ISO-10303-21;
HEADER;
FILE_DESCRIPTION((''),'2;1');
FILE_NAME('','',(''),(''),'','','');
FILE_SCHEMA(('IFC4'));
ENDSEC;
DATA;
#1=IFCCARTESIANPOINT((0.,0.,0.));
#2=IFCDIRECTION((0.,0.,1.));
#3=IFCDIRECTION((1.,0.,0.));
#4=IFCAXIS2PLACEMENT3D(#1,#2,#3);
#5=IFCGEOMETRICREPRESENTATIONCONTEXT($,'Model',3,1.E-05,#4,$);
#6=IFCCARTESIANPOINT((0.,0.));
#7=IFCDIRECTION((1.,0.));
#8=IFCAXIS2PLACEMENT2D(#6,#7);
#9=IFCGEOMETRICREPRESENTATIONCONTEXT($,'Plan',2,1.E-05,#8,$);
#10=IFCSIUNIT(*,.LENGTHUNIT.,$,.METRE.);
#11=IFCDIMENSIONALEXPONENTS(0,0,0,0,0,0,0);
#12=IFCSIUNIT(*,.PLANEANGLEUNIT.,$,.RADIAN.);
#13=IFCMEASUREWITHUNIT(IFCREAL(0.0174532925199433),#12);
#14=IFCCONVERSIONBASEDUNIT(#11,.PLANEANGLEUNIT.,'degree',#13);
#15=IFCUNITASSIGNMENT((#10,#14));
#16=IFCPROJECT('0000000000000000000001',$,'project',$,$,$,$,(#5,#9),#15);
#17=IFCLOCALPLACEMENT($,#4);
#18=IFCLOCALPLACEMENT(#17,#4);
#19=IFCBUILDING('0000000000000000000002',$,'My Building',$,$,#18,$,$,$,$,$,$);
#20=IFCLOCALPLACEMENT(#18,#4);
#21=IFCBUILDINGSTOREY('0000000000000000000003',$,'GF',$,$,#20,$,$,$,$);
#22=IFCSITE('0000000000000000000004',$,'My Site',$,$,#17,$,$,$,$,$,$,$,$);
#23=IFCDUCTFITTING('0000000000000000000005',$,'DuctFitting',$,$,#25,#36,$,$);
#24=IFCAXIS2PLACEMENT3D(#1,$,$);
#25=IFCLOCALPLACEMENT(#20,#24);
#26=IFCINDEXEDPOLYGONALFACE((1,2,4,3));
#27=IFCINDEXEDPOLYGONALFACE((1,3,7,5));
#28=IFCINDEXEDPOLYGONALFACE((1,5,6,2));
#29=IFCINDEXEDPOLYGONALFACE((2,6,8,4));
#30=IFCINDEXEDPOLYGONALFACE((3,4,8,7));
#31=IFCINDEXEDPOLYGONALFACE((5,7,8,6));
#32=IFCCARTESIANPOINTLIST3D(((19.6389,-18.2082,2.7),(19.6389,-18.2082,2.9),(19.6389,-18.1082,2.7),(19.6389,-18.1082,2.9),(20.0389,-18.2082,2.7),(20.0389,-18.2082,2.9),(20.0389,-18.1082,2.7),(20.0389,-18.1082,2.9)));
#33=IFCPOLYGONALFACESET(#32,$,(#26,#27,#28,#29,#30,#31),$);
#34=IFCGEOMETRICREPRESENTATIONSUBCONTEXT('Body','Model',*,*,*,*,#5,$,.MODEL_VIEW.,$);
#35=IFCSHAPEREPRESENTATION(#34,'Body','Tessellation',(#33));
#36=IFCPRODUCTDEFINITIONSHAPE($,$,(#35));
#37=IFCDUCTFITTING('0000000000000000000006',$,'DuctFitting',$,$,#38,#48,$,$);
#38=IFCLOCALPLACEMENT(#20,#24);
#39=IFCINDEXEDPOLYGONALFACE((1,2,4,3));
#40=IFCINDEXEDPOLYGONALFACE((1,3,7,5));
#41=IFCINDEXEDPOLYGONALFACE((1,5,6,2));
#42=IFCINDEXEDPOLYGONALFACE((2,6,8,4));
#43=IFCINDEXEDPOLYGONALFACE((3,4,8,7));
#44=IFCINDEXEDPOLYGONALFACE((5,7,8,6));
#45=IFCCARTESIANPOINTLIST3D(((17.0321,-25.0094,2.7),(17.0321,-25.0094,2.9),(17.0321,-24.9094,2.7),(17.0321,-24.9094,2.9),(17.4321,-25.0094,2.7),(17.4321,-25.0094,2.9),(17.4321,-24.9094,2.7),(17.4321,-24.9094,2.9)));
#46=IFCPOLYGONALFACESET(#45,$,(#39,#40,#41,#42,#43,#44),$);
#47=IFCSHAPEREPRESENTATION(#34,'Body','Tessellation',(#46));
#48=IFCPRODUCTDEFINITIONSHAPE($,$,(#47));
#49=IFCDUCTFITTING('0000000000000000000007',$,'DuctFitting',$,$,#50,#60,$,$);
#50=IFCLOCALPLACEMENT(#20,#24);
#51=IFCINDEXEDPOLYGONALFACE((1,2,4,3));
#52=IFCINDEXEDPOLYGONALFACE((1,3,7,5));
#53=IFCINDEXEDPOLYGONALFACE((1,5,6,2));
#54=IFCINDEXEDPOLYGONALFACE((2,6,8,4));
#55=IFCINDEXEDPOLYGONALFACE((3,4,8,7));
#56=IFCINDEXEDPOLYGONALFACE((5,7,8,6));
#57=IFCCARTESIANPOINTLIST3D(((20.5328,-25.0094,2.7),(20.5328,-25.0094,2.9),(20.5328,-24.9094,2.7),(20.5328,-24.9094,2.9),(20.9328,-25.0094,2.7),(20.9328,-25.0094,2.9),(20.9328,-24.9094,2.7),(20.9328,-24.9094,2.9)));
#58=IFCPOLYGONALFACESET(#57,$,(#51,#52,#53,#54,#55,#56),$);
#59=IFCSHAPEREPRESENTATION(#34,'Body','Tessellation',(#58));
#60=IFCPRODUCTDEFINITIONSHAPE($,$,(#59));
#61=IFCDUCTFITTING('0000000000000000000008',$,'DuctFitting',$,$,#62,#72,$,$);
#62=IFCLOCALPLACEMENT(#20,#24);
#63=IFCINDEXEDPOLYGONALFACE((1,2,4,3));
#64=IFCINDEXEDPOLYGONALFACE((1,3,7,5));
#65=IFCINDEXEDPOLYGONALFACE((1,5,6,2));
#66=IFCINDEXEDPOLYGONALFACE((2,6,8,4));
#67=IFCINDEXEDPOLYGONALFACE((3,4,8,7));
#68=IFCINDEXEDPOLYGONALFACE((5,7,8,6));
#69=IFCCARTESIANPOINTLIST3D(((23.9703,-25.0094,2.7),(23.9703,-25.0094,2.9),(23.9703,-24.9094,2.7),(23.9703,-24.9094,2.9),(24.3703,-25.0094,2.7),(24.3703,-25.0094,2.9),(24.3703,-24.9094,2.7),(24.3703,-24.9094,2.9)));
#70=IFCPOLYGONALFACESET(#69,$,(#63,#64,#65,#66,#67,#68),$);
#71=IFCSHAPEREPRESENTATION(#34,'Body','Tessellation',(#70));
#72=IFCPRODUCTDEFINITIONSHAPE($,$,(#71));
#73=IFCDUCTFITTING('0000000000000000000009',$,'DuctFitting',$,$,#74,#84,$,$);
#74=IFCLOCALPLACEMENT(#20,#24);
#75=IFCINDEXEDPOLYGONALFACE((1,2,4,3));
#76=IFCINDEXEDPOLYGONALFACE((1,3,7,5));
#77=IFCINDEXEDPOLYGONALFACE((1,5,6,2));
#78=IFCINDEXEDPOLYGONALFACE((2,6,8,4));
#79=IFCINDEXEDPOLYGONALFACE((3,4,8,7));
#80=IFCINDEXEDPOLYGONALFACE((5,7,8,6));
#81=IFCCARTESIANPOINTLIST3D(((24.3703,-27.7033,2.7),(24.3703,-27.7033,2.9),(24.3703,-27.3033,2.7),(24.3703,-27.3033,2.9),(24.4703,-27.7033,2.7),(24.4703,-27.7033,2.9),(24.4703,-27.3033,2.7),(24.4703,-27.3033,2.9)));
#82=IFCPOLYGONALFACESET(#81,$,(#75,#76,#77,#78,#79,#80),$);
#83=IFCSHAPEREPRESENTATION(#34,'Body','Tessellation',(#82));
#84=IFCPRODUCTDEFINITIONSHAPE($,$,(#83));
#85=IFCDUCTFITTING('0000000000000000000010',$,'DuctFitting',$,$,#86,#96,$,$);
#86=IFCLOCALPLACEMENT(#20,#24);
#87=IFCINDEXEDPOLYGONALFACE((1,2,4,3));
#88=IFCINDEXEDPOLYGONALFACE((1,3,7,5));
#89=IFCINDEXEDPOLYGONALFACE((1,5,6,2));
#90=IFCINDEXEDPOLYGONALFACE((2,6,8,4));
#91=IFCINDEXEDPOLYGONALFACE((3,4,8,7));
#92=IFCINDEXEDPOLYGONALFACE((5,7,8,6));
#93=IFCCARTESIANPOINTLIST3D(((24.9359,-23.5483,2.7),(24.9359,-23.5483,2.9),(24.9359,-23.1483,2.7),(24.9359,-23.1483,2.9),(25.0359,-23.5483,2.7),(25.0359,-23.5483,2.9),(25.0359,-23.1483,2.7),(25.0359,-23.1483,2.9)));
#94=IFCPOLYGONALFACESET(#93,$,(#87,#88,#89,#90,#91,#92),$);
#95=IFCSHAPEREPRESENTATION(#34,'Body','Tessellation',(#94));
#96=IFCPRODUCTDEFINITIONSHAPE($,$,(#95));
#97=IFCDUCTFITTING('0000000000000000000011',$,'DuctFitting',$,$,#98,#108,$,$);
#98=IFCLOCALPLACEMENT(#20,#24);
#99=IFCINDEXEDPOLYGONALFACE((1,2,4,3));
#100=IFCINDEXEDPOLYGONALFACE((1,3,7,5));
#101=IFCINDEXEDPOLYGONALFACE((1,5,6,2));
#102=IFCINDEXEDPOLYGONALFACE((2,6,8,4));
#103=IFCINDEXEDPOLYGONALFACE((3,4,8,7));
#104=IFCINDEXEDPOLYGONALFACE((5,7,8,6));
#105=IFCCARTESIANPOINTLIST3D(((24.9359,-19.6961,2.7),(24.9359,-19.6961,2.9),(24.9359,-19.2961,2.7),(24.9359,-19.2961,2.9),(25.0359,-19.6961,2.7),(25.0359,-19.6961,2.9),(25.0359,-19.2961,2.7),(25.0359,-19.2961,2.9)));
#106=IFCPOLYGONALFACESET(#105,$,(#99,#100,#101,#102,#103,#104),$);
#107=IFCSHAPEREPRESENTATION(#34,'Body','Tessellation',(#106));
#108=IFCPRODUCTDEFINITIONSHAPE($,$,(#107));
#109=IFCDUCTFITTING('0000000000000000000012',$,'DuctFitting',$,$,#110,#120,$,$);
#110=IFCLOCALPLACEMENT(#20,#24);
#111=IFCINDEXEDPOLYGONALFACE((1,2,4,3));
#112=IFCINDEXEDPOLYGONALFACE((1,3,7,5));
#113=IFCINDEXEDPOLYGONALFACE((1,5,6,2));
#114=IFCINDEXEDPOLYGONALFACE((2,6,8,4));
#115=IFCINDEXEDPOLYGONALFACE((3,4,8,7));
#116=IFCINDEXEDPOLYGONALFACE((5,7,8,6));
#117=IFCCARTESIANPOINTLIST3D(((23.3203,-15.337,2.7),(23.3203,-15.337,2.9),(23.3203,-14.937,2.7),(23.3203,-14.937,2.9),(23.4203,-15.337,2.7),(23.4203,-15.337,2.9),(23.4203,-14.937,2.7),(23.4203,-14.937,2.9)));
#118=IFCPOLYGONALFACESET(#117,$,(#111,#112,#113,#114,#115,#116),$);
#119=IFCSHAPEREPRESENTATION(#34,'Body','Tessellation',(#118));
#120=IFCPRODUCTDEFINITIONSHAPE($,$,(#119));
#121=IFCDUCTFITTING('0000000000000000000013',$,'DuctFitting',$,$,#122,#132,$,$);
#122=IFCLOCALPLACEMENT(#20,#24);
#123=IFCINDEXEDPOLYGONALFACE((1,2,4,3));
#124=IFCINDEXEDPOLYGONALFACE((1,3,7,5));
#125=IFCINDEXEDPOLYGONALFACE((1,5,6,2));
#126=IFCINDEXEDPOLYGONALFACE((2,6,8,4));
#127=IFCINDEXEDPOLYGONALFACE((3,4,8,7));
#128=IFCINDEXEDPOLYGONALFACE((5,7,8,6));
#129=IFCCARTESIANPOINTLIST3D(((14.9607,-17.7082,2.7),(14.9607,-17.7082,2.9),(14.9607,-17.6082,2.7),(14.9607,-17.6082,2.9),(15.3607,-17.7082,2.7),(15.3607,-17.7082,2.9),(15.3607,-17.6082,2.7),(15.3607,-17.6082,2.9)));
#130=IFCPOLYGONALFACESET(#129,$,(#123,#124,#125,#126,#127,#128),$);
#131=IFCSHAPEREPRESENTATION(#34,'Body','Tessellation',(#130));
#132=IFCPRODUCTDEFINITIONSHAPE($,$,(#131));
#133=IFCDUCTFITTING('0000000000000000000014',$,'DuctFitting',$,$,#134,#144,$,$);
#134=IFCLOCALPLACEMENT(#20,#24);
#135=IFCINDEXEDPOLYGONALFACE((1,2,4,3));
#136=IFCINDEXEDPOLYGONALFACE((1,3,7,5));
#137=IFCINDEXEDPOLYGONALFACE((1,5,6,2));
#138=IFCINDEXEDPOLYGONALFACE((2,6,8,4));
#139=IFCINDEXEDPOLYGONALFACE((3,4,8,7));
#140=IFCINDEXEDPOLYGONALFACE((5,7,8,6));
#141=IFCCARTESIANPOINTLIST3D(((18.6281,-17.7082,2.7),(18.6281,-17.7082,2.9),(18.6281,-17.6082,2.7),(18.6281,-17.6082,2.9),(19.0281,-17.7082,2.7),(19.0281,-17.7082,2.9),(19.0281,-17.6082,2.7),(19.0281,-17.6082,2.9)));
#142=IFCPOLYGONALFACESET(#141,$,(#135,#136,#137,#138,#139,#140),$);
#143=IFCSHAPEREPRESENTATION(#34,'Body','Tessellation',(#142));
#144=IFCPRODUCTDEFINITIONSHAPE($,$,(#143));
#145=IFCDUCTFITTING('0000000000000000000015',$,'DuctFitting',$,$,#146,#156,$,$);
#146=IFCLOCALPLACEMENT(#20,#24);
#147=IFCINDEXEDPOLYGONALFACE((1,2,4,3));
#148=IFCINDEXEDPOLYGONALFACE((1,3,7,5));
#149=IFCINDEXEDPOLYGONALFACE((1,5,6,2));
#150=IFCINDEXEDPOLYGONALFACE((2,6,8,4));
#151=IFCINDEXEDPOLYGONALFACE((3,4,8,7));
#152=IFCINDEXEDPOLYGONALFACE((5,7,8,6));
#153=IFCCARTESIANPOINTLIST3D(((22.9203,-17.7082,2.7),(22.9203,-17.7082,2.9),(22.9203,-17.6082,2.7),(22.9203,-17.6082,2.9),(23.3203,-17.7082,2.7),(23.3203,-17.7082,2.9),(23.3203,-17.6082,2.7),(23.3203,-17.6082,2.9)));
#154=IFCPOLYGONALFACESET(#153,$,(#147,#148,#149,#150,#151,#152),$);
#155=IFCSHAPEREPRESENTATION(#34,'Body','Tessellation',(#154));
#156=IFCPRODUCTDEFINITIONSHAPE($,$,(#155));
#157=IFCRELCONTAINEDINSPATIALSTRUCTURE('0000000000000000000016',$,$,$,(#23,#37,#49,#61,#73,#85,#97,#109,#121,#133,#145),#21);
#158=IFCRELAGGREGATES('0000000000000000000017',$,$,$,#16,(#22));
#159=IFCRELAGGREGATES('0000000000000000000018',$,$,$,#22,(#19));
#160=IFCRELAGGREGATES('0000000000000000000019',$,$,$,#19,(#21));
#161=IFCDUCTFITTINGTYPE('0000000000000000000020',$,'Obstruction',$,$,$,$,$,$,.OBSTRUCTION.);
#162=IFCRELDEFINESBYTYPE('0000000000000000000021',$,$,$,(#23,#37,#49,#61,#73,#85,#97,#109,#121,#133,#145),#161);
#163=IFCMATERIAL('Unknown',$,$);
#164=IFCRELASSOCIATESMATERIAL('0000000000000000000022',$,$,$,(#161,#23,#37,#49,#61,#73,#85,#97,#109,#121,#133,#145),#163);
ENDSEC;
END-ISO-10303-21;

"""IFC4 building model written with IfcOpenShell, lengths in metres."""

from ifc_helpers import new_model, entity, si_unit, converted_unit, frame, origin_with_axes, origin_2d_with_axis, place, context, subcontext, project, spatial, rectangle, extrude, material, material_profile, profile_set, profile_usage, type_object, element, save


model = new_model("IFC4")

# Units and contexts
model_context = context("Model", 3, precision=1e-05, world=origin_with_axes())
plan_context = context("Plan", 2, precision=1e-05, world=origin_2d_with_axis())
body_context_1 = subcontext(model_context, "Body", "Model", "MODEL_VIEW")
ifc_project = project(units=[si_unit("LENGTHUNIT", "METRE"), converted_unit("PLANEANGLEUNIT", "degree", entity("IfcReal", 0.0174532925199433), si_unit("PLANEANGLEUNIT", "RADIAN"), dimensions=[0, 0, 0, 0, 0, 0, 0])], contexts=[model_context, plan_context])

# Site, building, storey
site_placement = place(None, origin_with_axes())
site = spatial("IfcSite", under=ifc_project, at=site_placement, Name="My Site")
building_placement = place(site_placement, origin_with_axes())
building = spatial("IfcBuilding", under=site, at=building_placement, Name="My Building")
storey_placement = place(building_placement, origin_with_axes())
storey = spatial("IfcBuildingStorey", under=building, at=storey_placement, Name="GF")

# Shared definitions
ifc_material = material(Name="Unknown")

# Duct fittings
ifc_material_profile = material_profile(ifc_material, rectangle(XDim=0.4, YDim=0.2))
ifc_profile_set = profile_set([ifc_material_profile])
duct_fitting_type = type_object("IfcDuctFittingType", Name="Obstruction", PredefinedType="OBSTRUCTION", material=ifc_profile_set)
ifc_profile_usage_1 = profile_usage(ifc_profile_set, cardinal=5)
duct_fitting_1_placement = place(storey_placement, frame((19.8389, -18.2082, 2.8), z_axis=(0.0, 1.0, 0.0), x_axis=(-1.0, 0.0, 0.0)))
element("IfcDuctFitting", 1, at=duct_fitting_1_placement, inside=storey, type_object=duct_fitting_type, material=ifc_profile_usage_1, Name="DuctFitting", context=body_context_1, shape_type="SweptSolid", body=[
    extrude(rectangle(XDim=0.4, YDim=0.2), origin_with_axes(), (0.0, 0.0, 1.0), 0.1),
])
ifc_profile_usage_2 = profile_usage(ifc_profile_set, cardinal=5)
duct_fitting_2_placement = place(storey_placement, frame((17.2321, -25.0094, 2.8), z_axis=(0.0, 1.0, 0.0), x_axis=(-1.0, 0.0, 0.0)))
element("IfcDuctFitting", 2, at=duct_fitting_2_placement, inside=storey, type_object=duct_fitting_type, material=ifc_profile_usage_2, Name="DuctFitting", context=body_context_1, shape_type="SweptSolid", body=[
    extrude(rectangle(XDim=0.4, YDim=0.2), origin_with_axes(), (0.0, 0.0, 1.0), 0.1),
])
ifc_profile_usage_3 = profile_usage(ifc_profile_set, cardinal=5)
duct_fitting_3_placement = place(storey_placement, frame((20.7328, -25.0094, 2.8), z_axis=(0.0, 1.0, 0.0), x_axis=(-1.0, 0.0, 0.0)))
element("IfcDuctFitting", 3, at=duct_fitting_3_placement, inside=storey, type_object=duct_fitting_type, material=ifc_profile_usage_3, Name="DuctFitting", context=body_context_1, shape_type="SweptSolid", body=[
    extrude(rectangle(XDim=0.4, YDim=0.2), origin_with_axes(), (0.0, 0.0, 1.0), 0.1),
])
ifc_profile_usage_4 = profile_usage(ifc_profile_set, cardinal=5)
duct_fitting_4_placement = place(storey_placement, frame((24.1703, -24.9094, 2.8), z_axis=(0.0, -1.0, 0.0), x_axis=(1.0, 0.0, 0.0)))
element("IfcDuctFitting", 4, at=duct_fitting_4_placement, inside=storey, type_object=duct_fitting_type, material=ifc_profile_usage_4, Name="DuctFitting", context=body_context_1, shape_type="SweptSolid", body=[
    extrude(rectangle(XDim=0.4, YDim=0.2), origin_with_axes(), (0.0, 0.0, 1.0), 0.1),
])
ifc_profile_usage_5 = profile_usage(ifc_profile_set, cardinal=5)
duct_fitting_5_placement = place(storey_placement, frame((24.3703, -27.5033, 2.8), z_axis=(1.0, 0.0, 0.0), x_axis=(0.0, 1.0, 0.0)))
element("IfcDuctFitting", 5, at=duct_fitting_5_placement, inside=storey, type_object=duct_fitting_type, material=ifc_profile_usage_5, Name="DuctFitting", context=body_context_1, shape_type="SweptSolid", body=[
    extrude(rectangle(XDim=0.4, YDim=0.2), origin_with_axes(), (0.0, 0.0, 1.0), 0.1),
])
ifc_profile_usage_6 = profile_usage(ifc_profile_set, cardinal=5)
duct_fitting_6_placement = place(storey_placement, frame((24.9359, -23.3483, 2.8), z_axis=(1.0, 0.0, 0.0), x_axis=(0.0, 1.0, 0.0)))
element("IfcDuctFitting", 6, at=duct_fitting_6_placement, inside=storey, type_object=duct_fitting_type, material=ifc_profile_usage_6, Name="DuctFitting", context=body_context_1, shape_type="SweptSolid", body=[
    extrude(rectangle(XDim=0.4, YDim=0.2), origin_with_axes(), (0.0, 0.0, 1.0), 0.1),
])
ifc_profile_usage_7 = profile_usage(ifc_profile_set, cardinal=5)
duct_fitting_7_placement = place(storey_placement, frame((24.9359, -19.4961, 2.8), z_axis=(1.0, 0.0, 0.0), x_axis=(0.0, 1.0, 0.0)))
element("IfcDuctFitting", 7, at=duct_fitting_7_placement, inside=storey, type_object=duct_fitting_type, material=ifc_profile_usage_7, Name="DuctFitting", context=body_context_1, shape_type="SweptSolid", body=[
    extrude(rectangle(XDim=0.4, YDim=0.2), origin_with_axes(), (0.0, 0.0, 1.0), 0.1),
])
ifc_profile_usage_8 = profile_usage(ifc_profile_set, cardinal=5)
duct_fitting_8_placement = place(storey_placement, frame((23.3203, -15.137, 2.8), z_axis=(1.0, 0.0, 0.0), x_axis=(0.0, 1.0, 0.0)))
element("IfcDuctFitting", 8, at=duct_fitting_8_placement, inside=storey, type_object=duct_fitting_type, material=ifc_profile_usage_8, Name="DuctFitting", context=body_context_1, shape_type="SweptSolid", body=[
    extrude(rectangle(XDim=0.4, YDim=0.2), origin_with_axes(), (0.0, 0.0, 1.0), 0.1),
])
ifc_profile_usage_9 = profile_usage(ifc_profile_set, cardinal=5)
duct_fitting_9_placement = place(storey_placement, frame((15.1607, -17.6082, 2.8), z_axis=(0.0, -1.0, 0.0), x_axis=(1.0, 0.0, 0.0)))
element("IfcDuctFitting", 9, at=duct_fitting_9_placement, inside=storey, type_object=duct_fitting_type, material=ifc_profile_usage_9, Name="DuctFitting", context=body_context_1, shape_type="SweptSolid", body=[
    extrude(rectangle(XDim=0.4, YDim=0.2), origin_with_axes(), (0.0, 0.0, 1.0), 0.1),
])
ifc_profile_usage_10 = profile_usage(ifc_profile_set, cardinal=5)
duct_fitting_10_placement = place(storey_placement, frame((18.8281, -17.6082, 2.8), z_axis=(0.0, -1.0, 0.0), x_axis=(1.0, 0.0, 0.0)))
element("IfcDuctFitting", 10, at=duct_fitting_10_placement, inside=storey, type_object=duct_fitting_type, material=ifc_profile_usage_10, Name="DuctFitting", context=body_context_1, shape_type="SweptSolid", body=[
    extrude(rectangle(XDim=0.4, YDim=0.2), origin_with_axes(), (0.0, 0.0, 1.0), 0.1),
])
ifc_profile_usage_11 = profile_usage(ifc_profile_set, cardinal=5)
duct_fitting_11_placement = place(storey_placement, frame((23.1203, -17.7082, 2.8), z_axis=(0.0, 1.0, 0.0), x_axis=(-1.0, 0.0, 0.0)))
element("IfcDuctFitting", 11, at=duct_fitting_11_placement, inside=storey, type_object=duct_fitting_type, material=ifc_profile_usage_11, Name="DuctFitting", context=body_context_1, shape_type="SweptSolid", body=[
    extrude(rectangle(XDim=0.4, YDim=0.2), origin_with_axes(), (0.0, 0.0, 1.0), 0.1),
])

save(model, "model.ifc")
